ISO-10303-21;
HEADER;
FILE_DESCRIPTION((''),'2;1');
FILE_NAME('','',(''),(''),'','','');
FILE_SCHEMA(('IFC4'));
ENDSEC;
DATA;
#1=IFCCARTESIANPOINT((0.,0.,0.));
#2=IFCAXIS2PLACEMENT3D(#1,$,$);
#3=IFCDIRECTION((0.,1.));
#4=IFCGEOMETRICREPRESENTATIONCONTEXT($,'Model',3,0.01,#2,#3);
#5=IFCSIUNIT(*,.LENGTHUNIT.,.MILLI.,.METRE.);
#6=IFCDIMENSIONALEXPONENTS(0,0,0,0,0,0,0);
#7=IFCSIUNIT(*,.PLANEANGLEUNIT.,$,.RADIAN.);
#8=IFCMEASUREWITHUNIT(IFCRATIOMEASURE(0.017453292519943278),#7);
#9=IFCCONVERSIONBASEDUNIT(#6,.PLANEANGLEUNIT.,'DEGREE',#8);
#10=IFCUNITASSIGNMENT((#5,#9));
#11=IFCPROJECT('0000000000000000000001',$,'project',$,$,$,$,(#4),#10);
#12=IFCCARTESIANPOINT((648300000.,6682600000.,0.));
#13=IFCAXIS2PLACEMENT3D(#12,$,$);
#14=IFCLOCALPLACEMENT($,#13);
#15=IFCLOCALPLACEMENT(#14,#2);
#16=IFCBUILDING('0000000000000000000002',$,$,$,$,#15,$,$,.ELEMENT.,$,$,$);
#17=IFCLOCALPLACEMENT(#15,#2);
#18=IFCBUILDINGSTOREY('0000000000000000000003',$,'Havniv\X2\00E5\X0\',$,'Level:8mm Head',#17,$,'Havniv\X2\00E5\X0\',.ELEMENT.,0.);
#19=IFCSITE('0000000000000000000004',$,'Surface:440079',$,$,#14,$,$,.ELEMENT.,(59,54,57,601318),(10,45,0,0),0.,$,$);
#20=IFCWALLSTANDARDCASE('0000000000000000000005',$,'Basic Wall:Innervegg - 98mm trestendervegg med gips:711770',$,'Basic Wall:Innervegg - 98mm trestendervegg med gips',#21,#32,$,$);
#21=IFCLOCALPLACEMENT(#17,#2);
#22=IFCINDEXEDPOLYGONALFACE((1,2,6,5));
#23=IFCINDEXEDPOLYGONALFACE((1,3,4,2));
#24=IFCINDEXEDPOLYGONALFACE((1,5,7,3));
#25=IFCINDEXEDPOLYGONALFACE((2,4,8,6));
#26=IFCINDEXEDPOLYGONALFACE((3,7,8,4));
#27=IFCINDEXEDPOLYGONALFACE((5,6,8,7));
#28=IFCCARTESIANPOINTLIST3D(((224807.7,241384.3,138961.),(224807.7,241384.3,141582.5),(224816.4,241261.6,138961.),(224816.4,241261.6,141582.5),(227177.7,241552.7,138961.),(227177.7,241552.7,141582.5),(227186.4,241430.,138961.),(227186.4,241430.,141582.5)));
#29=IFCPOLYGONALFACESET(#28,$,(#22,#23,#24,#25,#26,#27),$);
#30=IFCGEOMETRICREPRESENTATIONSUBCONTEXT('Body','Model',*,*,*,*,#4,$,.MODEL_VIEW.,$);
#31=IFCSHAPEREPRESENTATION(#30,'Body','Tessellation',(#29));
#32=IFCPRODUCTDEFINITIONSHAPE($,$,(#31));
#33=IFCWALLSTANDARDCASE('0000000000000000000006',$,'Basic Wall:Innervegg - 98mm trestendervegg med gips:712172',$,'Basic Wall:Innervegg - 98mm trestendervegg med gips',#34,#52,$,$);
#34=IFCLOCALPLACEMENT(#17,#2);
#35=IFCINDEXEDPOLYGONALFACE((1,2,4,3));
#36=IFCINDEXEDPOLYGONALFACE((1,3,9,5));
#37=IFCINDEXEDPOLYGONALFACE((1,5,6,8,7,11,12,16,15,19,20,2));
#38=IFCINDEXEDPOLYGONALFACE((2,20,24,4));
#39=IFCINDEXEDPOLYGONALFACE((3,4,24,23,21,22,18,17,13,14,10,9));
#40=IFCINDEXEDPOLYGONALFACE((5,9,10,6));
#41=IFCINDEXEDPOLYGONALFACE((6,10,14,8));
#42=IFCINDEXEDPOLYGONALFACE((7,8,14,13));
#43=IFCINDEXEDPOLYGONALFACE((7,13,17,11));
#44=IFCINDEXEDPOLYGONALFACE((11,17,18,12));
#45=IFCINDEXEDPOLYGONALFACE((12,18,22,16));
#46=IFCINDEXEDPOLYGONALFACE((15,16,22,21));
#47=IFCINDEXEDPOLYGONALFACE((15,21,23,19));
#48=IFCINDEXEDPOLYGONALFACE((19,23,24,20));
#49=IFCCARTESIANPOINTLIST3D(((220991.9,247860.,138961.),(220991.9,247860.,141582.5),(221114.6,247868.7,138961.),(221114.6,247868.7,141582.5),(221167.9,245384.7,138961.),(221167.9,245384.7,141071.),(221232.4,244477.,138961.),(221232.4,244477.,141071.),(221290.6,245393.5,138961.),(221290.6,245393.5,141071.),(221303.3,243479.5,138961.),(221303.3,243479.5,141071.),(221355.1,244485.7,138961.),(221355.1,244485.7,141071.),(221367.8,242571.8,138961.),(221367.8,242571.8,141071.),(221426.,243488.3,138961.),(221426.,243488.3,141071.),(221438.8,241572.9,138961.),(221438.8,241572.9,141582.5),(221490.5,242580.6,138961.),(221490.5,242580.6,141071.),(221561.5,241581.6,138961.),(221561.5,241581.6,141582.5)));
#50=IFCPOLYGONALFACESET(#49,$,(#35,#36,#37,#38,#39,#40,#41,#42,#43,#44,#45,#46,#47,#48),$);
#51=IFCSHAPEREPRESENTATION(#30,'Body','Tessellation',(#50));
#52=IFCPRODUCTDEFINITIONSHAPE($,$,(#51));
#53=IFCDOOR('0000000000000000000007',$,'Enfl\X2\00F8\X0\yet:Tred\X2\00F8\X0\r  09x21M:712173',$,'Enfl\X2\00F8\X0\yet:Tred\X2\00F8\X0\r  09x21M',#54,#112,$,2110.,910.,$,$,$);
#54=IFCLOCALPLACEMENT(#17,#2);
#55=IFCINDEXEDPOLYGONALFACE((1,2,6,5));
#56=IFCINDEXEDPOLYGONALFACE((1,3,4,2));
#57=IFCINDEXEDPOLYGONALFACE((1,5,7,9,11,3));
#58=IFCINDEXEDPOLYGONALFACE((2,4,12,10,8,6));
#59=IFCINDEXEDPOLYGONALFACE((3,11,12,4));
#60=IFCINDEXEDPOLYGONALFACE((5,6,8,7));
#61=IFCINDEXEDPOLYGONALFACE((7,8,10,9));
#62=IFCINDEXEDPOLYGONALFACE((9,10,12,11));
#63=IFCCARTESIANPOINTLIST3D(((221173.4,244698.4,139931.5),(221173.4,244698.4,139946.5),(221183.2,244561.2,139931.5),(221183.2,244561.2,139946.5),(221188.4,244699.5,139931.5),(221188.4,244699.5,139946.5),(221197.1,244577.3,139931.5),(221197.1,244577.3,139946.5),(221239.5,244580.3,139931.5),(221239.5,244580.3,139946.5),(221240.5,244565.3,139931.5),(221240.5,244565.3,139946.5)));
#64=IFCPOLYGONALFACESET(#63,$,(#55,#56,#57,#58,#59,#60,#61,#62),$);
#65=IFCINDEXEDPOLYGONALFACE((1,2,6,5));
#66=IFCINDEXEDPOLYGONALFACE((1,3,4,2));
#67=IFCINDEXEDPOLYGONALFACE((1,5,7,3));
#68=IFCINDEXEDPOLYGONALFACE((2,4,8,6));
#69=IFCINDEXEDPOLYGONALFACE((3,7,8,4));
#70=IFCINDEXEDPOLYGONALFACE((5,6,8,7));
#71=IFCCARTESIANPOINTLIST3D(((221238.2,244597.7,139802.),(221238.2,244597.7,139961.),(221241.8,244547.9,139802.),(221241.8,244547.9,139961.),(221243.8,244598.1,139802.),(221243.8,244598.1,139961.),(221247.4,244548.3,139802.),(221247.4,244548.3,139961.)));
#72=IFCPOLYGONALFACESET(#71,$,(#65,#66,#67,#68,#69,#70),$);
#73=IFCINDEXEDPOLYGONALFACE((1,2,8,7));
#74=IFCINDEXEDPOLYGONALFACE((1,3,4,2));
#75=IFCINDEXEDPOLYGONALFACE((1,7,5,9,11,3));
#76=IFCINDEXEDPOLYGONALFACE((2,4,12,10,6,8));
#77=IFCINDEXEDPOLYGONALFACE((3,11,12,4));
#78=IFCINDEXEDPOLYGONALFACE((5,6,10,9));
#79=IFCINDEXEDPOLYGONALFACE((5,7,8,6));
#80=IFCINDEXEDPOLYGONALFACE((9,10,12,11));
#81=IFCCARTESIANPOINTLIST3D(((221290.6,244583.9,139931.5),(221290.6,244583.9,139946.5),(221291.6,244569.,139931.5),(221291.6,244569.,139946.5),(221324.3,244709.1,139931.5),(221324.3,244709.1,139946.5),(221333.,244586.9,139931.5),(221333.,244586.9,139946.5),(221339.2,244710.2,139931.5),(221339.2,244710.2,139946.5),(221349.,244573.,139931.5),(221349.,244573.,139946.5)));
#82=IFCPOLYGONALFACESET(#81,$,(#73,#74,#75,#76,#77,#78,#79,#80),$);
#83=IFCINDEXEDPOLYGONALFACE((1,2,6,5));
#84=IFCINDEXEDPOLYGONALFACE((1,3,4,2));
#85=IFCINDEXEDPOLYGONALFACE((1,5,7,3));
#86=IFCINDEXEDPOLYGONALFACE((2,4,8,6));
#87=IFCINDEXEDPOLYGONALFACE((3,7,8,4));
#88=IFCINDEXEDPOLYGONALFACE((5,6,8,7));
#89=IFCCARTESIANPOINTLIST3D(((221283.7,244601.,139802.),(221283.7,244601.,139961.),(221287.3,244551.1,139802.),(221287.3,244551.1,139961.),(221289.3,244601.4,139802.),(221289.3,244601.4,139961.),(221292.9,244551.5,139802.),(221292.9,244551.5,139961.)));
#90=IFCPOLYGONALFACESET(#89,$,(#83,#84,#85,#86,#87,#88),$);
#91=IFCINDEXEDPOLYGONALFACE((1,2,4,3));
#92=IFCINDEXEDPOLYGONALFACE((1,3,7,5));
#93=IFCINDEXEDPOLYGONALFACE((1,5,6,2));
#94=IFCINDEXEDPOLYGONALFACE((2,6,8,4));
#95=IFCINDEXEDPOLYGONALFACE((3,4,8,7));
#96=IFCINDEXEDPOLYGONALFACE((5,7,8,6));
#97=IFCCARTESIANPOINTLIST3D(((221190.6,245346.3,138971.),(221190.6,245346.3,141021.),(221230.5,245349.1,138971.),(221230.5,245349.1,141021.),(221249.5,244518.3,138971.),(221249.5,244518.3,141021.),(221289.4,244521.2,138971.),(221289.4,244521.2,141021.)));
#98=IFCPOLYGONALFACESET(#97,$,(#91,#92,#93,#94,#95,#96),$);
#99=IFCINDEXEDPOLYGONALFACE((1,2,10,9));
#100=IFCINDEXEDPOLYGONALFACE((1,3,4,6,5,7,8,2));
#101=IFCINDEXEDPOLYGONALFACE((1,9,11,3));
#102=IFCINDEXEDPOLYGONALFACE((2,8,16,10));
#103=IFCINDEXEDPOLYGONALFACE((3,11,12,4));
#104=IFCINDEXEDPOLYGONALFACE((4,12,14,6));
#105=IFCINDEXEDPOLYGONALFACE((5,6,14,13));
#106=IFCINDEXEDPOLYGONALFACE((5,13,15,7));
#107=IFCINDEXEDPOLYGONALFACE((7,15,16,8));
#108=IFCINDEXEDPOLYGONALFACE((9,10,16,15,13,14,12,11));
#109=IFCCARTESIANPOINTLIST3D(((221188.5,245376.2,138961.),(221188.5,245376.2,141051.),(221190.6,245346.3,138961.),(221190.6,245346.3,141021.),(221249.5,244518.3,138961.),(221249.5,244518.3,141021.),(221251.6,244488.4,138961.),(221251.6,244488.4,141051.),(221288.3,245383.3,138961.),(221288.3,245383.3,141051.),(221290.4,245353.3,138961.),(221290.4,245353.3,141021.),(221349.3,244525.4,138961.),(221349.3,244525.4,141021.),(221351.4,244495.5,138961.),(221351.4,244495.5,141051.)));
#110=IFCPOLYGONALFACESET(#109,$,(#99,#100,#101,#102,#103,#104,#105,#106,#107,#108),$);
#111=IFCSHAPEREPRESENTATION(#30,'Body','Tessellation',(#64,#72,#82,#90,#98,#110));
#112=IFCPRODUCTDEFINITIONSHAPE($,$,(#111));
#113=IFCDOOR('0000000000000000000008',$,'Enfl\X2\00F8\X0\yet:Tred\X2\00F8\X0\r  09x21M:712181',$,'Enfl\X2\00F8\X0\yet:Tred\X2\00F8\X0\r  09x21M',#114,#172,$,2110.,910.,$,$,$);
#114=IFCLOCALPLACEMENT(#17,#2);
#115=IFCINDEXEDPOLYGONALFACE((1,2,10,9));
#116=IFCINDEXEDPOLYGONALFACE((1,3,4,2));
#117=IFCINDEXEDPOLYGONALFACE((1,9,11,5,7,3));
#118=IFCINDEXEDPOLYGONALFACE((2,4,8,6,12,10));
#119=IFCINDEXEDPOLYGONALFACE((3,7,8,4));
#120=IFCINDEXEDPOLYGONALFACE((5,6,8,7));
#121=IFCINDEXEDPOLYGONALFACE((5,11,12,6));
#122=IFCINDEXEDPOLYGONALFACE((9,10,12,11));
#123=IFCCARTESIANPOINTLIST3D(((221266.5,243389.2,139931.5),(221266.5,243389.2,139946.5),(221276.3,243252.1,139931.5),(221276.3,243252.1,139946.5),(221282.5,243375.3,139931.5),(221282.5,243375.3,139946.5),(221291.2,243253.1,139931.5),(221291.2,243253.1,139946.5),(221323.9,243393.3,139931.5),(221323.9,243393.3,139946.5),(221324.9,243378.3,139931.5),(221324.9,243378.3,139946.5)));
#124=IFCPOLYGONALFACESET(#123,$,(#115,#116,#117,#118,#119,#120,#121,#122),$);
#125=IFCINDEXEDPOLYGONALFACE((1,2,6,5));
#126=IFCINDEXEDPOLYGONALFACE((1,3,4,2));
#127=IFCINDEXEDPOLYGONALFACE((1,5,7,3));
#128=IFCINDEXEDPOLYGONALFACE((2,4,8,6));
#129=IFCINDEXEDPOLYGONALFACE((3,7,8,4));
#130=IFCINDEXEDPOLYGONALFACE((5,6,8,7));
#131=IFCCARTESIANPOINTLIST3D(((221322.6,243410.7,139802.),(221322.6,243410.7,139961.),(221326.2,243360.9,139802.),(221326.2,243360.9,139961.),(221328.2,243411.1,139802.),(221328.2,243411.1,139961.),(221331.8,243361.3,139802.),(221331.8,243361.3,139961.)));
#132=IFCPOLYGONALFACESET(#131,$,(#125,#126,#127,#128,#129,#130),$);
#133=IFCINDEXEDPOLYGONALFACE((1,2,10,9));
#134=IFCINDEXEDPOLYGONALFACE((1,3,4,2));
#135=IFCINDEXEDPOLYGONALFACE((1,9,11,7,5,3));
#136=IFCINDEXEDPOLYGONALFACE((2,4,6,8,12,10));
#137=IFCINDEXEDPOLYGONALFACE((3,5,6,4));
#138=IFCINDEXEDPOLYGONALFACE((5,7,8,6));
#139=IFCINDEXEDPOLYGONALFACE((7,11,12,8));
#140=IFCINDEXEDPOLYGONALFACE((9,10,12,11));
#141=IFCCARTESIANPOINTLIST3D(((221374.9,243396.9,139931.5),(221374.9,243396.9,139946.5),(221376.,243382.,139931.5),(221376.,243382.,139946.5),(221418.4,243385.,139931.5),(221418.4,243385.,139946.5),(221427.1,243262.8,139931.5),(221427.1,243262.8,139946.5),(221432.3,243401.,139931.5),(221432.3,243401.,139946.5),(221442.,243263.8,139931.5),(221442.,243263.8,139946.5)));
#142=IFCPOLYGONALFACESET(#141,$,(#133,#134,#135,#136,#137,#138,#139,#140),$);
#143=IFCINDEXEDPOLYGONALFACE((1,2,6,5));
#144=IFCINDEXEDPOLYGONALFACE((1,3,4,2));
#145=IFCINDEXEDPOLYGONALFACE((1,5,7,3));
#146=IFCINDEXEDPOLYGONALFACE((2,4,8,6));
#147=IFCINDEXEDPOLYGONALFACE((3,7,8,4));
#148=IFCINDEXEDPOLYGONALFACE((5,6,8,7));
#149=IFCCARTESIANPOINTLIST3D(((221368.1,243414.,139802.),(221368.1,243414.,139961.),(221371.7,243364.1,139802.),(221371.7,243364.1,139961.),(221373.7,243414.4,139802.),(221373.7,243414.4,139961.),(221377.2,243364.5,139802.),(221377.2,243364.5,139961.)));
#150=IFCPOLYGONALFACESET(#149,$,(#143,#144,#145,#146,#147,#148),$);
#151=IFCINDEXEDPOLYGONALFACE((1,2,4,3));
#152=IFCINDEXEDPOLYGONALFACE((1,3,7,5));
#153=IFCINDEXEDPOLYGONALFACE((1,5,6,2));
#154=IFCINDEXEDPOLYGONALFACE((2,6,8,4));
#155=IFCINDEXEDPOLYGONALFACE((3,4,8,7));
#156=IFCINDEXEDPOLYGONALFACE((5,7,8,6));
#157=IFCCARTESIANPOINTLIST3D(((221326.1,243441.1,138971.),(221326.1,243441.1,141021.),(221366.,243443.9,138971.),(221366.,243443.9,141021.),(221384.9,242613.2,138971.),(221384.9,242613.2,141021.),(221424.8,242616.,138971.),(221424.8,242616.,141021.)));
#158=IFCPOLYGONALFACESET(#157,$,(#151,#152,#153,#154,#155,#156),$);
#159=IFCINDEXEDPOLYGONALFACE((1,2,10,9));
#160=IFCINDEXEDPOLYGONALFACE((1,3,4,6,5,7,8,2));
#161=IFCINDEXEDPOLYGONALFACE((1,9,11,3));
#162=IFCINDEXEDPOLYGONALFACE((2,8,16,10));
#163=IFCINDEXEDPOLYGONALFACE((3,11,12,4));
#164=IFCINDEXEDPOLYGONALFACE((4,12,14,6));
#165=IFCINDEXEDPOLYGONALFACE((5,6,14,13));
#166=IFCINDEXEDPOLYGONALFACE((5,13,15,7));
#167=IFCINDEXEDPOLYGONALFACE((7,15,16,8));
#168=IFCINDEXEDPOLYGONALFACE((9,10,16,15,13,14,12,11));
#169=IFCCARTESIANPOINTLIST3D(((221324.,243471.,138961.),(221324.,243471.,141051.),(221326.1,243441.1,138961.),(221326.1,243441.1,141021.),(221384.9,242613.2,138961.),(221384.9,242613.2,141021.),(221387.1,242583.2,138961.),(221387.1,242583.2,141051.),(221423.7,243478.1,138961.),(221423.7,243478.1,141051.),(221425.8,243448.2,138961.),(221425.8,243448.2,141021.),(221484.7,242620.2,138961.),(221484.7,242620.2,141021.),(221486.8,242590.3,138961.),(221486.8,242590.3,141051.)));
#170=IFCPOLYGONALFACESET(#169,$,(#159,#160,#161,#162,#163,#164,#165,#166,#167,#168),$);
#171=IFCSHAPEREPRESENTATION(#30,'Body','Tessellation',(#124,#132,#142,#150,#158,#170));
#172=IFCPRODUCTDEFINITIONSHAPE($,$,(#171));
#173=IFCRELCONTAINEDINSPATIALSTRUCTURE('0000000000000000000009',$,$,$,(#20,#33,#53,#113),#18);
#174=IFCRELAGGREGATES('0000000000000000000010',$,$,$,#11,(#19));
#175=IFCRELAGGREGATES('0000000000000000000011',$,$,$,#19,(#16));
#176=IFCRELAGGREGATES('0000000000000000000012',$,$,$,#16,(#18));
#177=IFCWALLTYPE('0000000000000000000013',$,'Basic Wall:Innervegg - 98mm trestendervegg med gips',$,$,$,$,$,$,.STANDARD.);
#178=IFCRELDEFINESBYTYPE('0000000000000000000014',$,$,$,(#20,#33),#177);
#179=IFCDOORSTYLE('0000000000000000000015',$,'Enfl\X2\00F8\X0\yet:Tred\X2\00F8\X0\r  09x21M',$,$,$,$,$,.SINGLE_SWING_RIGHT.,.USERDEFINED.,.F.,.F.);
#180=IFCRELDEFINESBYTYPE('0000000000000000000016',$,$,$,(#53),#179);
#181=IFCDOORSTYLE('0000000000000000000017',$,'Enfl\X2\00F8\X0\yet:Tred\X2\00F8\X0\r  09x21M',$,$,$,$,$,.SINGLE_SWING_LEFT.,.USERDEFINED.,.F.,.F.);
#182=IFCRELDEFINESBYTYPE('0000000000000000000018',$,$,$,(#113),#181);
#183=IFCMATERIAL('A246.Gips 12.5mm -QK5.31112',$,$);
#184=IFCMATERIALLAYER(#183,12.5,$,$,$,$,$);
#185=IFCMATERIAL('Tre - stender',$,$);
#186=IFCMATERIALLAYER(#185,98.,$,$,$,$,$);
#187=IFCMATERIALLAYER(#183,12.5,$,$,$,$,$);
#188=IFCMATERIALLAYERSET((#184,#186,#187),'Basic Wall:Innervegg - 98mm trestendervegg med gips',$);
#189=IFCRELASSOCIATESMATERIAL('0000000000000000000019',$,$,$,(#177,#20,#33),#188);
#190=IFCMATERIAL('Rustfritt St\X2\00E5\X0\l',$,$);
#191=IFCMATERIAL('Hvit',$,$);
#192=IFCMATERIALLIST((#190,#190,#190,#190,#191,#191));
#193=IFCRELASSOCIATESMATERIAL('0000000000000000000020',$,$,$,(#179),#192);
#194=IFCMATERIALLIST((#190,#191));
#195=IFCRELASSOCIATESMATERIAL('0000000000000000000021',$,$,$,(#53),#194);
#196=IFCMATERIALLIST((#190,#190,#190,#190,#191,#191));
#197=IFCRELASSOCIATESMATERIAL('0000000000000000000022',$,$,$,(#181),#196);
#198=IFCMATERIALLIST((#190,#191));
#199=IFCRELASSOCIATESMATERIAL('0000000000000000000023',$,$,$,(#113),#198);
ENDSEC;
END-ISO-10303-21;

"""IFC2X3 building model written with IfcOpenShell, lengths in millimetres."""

from ifc_helpers import new_model, entity, si_unit, converted_unit, direction, frame, frame_2d, origin, origin_2d_with_axis, place, context, subcontext, project, spatial, polyline, rectangle, outline, extrude, source, transform, mapped, material, material_list, layer, layer_set, layer_usage, type_object, type_shapes, element, fill, save


model = new_model("IFC2X3")

# Units and contexts
model_context = context("Model", 3, precision=0.01, world=origin(), true_north=direction((0.0, 1.0)))
body_context = subcontext(model_context, "Body", "Model", "MODEL_VIEW")
ifc_project = project(units=[si_unit("LENGTHUNIT", "METRE", prefix="MILLI"), converted_unit("PLANEANGLEUNIT", "DEGREE", entity("IfcRatioMeasure", 0.017453292519943278), si_unit("PLANEANGLEUNIT", "RADIAN"), dimensions=[0, 0, 0, 0, 0, 0, 0])], contexts=[model_context])

# Site, building, storey
site_placement = place(None, frame((648300000.0, 6682600000.0, 0.0)))
site = spatial("IfcSite", under=ifc_project, at=site_placement, Name="Surface:440079", CompositionType="ELEMENT", RefLatitude=(59, 54, 57, 601318), RefLongitude=(10, 45, 0, 0), RefElevation=0.0)
building_placement = place(site_placement, origin())
building = spatial("IfcBuilding", under=site, at=building_placement, CompositionType="ELEMENT")
storey_placement = place(building_placement, origin())
storey = spatial("IfcBuildingStorey", under=building, at=storey_placement, Name="Havnivå", ObjectType="Level:8mm Head", LongName="Havnivå", CompositionType="ELEMENT", Elevation=0.0)

# Wall
ifc_material_1 = material(Name="A246.Gips 12.5mm -QK5.31112")
ifc_layer_1 = layer(ifc_material_1, 12.5)
ifc_material_2 = material(Name="Tre - stender")
ifc_layer_2 = layer(ifc_material_2, 98.0)
ifc_layer_3 = layer(ifc_material_1, 12.5)
ifc_layer_set_1 = layer_set([ifc_layer_1, ifc_layer_2, ifc_layer_3], Name="Basic Wall:Innervegg - 98mm trestendervegg med gips")
ifc_layer_usage_1 = layer_usage(ifc_layer_set_1, "AXIS2", "NEGATIVE", 61.5)
wall_type_1 = type_object("IfcWallType", Name="Basic Wall:Innervegg - 98mm trestendervegg med gips", PredefinedType="STANDARD", material=ifc_layer_set_1)
wall_1_placement = place(storey_placement, frame((224812.1, 241322.9, 138961.0), z_axis=(0.0, 0.0, 1.0), x_axis=(0.997483, 0.070908, 0.0)))
element("IfcWallStandardCase", 1, at=wall_1_placement, inside=storey, type_object=wall_type_1, material=ifc_layer_usage_1, Name="Basic Wall:Innervegg - 98mm trestendervegg med gips:711770", ObjectType="Basic Wall:Innervegg - 98mm trestendervegg med gips", context=body_context, shape_type="SweptSolid", body=[
    extrude(rectangle(XDim=2376.0, YDim=123.0, at=frame_2d((1188.0, 0.0), x_axis=(-1.0, 0.0))), origin(), (0.0, 0.0, 1.0), 2621.5),
])

# Wall, openings, doors
ifc_layer_usage_2 = layer_usage(ifc_layer_set_1, "AXIS2", "POSITIVE", -61.5)
wall_2_placement = place(storey_placement, frame((221500.2, 241577.2, 138961.0), z_axis=(0.0, 0.0, 1.0), x_axis=(-0.070908, 0.997483, 0.0)))
wall_2 = element("IfcWallStandardCase", 2, at=wall_2_placement, inside=storey, type_object=wall_type_1, material=ifc_layer_usage_2, Name="Basic Wall:Innervegg - 98mm trestendervegg med gips:712172", ObjectType="Basic Wall:Innervegg - 98mm trestendervegg med gips", context=body_context, shape_type="SweptSolid", body=[
    extrude(rectangle(XDim=6303.0, YDim=123.0, at=frame_2d((3151.5, 0.0), x_axis=(1.0, 0.0))), origin(), (0.0, 0.0, 1.0), 2621.5),
])
opening_1_placement = place(wall_2_placement, frame((2911.5, -61.5, 0.0)))
opening_1 = element("IfcOpeningElement", 3, at=opening_1_placement, cuts=wall_2, ObjectType="Opening", context=body_context, shape_type="SweptSolid", body=[
    extrude(rectangle(XDim=2110.0, YDim=910.0, at=frame_2d((1055.0, 455.0), x_axis=(1.0, 0.0))), frame((0.0, 0.0, 0.0), z_axis=(0.0, 1.0, 0.0), x_axis=(0.0, 0.0, 1.0)), (0.0, 0.0, 1.0), 123.0),
])
opening_2_placement = place(wall_2_placement, frame((1001.5, -61.5, 0.0)))
opening_2 = element("IfcOpeningElement", 4, at=opening_2_placement, cuts=wall_2, ObjectType="Opening", context=body_context, shape_type="SweptSolid", body=[
    extrude(rectangle(XDim=2110.0, YDim=910.0, at=frame_2d((1055.0, 455.0), x_axis=(1.0, 0.0))), frame((0.0, 0.0, 0.0), z_axis=(0.0, 1.0, 0.0), x_axis=(0.0, 0.0, 1.0)), (0.0, 0.0, 1.0), 123.0),
])
ifc_material_3 = material(Name="Rustfritt Stål")
ifc_material_4 = material(Name="Hvit")
ifc_material_list_1 = material_list([ifc_material_3, ifc_material_4])
ifc_material_list_2 = material_list([ifc_material_3, ifc_material_3, ifc_material_3, ifc_material_3, ifc_material_4, ifc_material_4])
door_style_1 = type_object("IfcDoorStyle", Name="Enfløyet:Tredør  09x21M", ConstructionType="USERDEFINED", OperationType="SINGLE_SWING_RIGHT", ParameterTakesPrecedence=False, Sizeable=False, material=ifc_material_list_2)
shared_shape_1 = source(origin(), body_context, "Body", "SweptSolid", [
    extrude(outline(polyline([(-50.8, -33.3), (-35.8, -33.3), (-35.8, 9.2), (86.7, 9.2), (86.7, 24.2), (-50.8, 24.2), (-50.8, -33.3)])), frame((138.3, 141.9, 970.5)), (0.0, 0.0, 1.0), 15.0),
    extrude(rectangle(XDim=50.0, YDim=5.6, at=frame_2d((0.0, 0.0), x_axis=(1.0, 0.0))), frame((95.0, 105.8, 841.0), z_axis=(0.0, 0.0, 1.0), x_axis=(-1.0, 0.0, 0.0)), (0.0, 0.0, 1.0), 159.0),
    extrude(outline(polyline([(-33.3, -50.8), (24.2, -50.8), (24.2, 86.7), (9.2, 86.7), (9.2, -35.8), (-33.3, -35.8), (-33.3, -50.8)])), frame((138.3, 24.1, 970.5), z_axis=(0.0, 0.0, 1.0), x_axis=(0.0, -1.0, 0.0)), (0.0, 0.0, 1.0), 15.0),
    extrude(rectangle(XDim=5.6, YDim=50.0, at=frame_2d((0.0, 0.0), x_axis=(1.0, 0.0))), frame((95.0, 60.2, 841.0), z_axis=(0.0, 0.0, 1.0), x_axis=(0.0, 1.0, 0.0)), (0.0, 0.0, 1.0), 159.0),
    extrude(rectangle(XDim=40.0, YDim=830.0, at=origin_2d_with_axis()), frame((455.0, 83.0, 10.0), z_axis=(0.0, 0.0, 1.0), x_axis=(0.0, -1.0, 0.0)), (0.0, 0.0, 1.0), 2050.0),
    extrude(outline(polyline([(-1037.5, -445.0), (1052.5, -445.0), (1052.5, 445.0), (-1037.5, 445.0), (-1037.5, 415.0), (1022.5, 415.0), (1022.5, -415.0), (-1037.5, -415.0), (-1037.5, -445.0)])), frame((455.0, 3.0, 1037.5), z_axis=(0.0, 1.0, 0.0), x_axis=(0.0, 0.0, 1.0)), (0.0, 0.0, 1.0), 100.0),
])
type_shapes(door_style_1, [shared_shape_1])
door_1_placement = place(opening_1_placement, origin())
door_1 = element("IfcDoor", 5, at=door_1_placement, inside=storey, type_object=door_style_1, material=ifc_material_list_1, Name="Enfløyet:Tredør  09x21M:712173", ObjectType="Enfløyet:Tredør  09x21M", OverallHeight=2110.0, OverallWidth=910.0, context=body_context, shape_type="MappedRepresentation", body=[
    mapped(shared_shape_1, transform((0.0, 0.0, 0.0), scale=1.0)),
])
fill(opening_1, door_1)
ifc_material_list_3 = material_list([ifc_material_3, ifc_material_4])
ifc_material_list_4 = material_list([ifc_material_3, ifc_material_3, ifc_material_3, ifc_material_3, ifc_material_4, ifc_material_4])
door_style_2 = type_object("IfcDoorStyle", Name="Enfløyet:Tredør  09x21M", ConstructionType="USERDEFINED", OperationType="SINGLE_SWING_LEFT", ParameterTakesPrecedence=False, Sizeable=False, material=ifc_material_list_4)
shared_shape_2 = source(origin(), body_context, "Body", "SweptSolid", [
    extrude(outline(polyline([(-33.3, -50.8), (24.2, -50.8), (24.2, 86.7), (9.2, 86.7), (9.2, -35.8), (-33.3, -35.8), (-33.3, -50.8)])), frame((771.7, 121.9, 970.5), z_axis=(0.0, 0.0, 1.0), x_axis=(0.0, 1.0, 0.0)), (0.0, 0.0, 1.0), 15.0),
    extrude(rectangle(XDim=5.6, YDim=50.0, at=frame_2d((0.0, 0.0), x_axis=(1.0, 0.0))), frame((815.0, 85.8, 841.0), z_axis=(0.0, 0.0, 1.0), x_axis=(0.0, -1.0, 0.0)), (0.0, 0.0, 1.0), 159.0),
    extrude(outline(polyline([(-50.8, -33.3), (-35.8, -33.3), (-35.8, 9.2), (86.7, 9.2), (86.7, 24.2), (-50.8, 24.2), (-50.8, -33.3)])), frame((771.7, 4.1, 970.5), z_axis=(0.0, 0.0, 1.0), x_axis=(-1.0, 0.0, 0.0)), (0.0, 0.0, 1.0), 15.0),
    extrude(rectangle(XDim=50.0, YDim=5.6, at=frame_2d((0.0, 0.0), x_axis=(1.0, 0.0))), frame((815.0, 40.2, 841.0)), (0.0, 0.0, 1.0), 159.0),
    extrude(rectangle(XDim=830.0, YDim=40.0, at=origin_2d_with_axis()), frame((455.0, 63.0, 10.0), z_axis=(0.0, 0.0, 1.0), x_axis=(-1.0, 0.0, 0.0)), (0.0, 0.0, 1.0), 2050.0),
    extrude(outline(polyline([(415.0, -1037.5), (445.0, -1037.5), (445.0, 1052.5), (-445.0, 1052.5), (-445.0, -1037.5), (-415.0, -1037.5), (-415.0, 1022.5), (415.0, 1022.5), (415.0, -1037.5)])), frame((455.0, 83.0, 1037.5), z_axis=(0.0, -1.0, 0.0), x_axis=(1.0, 0.0, 0.0)), (0.0, 0.0, 1.0), 100.0),
])
type_shapes(door_style_2, [shared_shape_2])
door_2_placement = place(opening_2_placement, frame((0.0, 20.0, 0.0)))
door_2 = element("IfcDoor", 6, at=door_2_placement, inside=storey, type_object=door_style_2, material=ifc_material_list_3, Name="Enfløyet:Tredør  09x21M:712181", ObjectType="Enfløyet:Tredør  09x21M", OverallHeight=2110.0, OverallWidth=910.0, context=body_context, shape_type="MappedRepresentation", body=[
    mapped(shared_shape_2, transform((0.0, 0.0, 0.0), scale=1.0)),
])
fill(opening_2, door_2)

save(model, "model.ifc")
